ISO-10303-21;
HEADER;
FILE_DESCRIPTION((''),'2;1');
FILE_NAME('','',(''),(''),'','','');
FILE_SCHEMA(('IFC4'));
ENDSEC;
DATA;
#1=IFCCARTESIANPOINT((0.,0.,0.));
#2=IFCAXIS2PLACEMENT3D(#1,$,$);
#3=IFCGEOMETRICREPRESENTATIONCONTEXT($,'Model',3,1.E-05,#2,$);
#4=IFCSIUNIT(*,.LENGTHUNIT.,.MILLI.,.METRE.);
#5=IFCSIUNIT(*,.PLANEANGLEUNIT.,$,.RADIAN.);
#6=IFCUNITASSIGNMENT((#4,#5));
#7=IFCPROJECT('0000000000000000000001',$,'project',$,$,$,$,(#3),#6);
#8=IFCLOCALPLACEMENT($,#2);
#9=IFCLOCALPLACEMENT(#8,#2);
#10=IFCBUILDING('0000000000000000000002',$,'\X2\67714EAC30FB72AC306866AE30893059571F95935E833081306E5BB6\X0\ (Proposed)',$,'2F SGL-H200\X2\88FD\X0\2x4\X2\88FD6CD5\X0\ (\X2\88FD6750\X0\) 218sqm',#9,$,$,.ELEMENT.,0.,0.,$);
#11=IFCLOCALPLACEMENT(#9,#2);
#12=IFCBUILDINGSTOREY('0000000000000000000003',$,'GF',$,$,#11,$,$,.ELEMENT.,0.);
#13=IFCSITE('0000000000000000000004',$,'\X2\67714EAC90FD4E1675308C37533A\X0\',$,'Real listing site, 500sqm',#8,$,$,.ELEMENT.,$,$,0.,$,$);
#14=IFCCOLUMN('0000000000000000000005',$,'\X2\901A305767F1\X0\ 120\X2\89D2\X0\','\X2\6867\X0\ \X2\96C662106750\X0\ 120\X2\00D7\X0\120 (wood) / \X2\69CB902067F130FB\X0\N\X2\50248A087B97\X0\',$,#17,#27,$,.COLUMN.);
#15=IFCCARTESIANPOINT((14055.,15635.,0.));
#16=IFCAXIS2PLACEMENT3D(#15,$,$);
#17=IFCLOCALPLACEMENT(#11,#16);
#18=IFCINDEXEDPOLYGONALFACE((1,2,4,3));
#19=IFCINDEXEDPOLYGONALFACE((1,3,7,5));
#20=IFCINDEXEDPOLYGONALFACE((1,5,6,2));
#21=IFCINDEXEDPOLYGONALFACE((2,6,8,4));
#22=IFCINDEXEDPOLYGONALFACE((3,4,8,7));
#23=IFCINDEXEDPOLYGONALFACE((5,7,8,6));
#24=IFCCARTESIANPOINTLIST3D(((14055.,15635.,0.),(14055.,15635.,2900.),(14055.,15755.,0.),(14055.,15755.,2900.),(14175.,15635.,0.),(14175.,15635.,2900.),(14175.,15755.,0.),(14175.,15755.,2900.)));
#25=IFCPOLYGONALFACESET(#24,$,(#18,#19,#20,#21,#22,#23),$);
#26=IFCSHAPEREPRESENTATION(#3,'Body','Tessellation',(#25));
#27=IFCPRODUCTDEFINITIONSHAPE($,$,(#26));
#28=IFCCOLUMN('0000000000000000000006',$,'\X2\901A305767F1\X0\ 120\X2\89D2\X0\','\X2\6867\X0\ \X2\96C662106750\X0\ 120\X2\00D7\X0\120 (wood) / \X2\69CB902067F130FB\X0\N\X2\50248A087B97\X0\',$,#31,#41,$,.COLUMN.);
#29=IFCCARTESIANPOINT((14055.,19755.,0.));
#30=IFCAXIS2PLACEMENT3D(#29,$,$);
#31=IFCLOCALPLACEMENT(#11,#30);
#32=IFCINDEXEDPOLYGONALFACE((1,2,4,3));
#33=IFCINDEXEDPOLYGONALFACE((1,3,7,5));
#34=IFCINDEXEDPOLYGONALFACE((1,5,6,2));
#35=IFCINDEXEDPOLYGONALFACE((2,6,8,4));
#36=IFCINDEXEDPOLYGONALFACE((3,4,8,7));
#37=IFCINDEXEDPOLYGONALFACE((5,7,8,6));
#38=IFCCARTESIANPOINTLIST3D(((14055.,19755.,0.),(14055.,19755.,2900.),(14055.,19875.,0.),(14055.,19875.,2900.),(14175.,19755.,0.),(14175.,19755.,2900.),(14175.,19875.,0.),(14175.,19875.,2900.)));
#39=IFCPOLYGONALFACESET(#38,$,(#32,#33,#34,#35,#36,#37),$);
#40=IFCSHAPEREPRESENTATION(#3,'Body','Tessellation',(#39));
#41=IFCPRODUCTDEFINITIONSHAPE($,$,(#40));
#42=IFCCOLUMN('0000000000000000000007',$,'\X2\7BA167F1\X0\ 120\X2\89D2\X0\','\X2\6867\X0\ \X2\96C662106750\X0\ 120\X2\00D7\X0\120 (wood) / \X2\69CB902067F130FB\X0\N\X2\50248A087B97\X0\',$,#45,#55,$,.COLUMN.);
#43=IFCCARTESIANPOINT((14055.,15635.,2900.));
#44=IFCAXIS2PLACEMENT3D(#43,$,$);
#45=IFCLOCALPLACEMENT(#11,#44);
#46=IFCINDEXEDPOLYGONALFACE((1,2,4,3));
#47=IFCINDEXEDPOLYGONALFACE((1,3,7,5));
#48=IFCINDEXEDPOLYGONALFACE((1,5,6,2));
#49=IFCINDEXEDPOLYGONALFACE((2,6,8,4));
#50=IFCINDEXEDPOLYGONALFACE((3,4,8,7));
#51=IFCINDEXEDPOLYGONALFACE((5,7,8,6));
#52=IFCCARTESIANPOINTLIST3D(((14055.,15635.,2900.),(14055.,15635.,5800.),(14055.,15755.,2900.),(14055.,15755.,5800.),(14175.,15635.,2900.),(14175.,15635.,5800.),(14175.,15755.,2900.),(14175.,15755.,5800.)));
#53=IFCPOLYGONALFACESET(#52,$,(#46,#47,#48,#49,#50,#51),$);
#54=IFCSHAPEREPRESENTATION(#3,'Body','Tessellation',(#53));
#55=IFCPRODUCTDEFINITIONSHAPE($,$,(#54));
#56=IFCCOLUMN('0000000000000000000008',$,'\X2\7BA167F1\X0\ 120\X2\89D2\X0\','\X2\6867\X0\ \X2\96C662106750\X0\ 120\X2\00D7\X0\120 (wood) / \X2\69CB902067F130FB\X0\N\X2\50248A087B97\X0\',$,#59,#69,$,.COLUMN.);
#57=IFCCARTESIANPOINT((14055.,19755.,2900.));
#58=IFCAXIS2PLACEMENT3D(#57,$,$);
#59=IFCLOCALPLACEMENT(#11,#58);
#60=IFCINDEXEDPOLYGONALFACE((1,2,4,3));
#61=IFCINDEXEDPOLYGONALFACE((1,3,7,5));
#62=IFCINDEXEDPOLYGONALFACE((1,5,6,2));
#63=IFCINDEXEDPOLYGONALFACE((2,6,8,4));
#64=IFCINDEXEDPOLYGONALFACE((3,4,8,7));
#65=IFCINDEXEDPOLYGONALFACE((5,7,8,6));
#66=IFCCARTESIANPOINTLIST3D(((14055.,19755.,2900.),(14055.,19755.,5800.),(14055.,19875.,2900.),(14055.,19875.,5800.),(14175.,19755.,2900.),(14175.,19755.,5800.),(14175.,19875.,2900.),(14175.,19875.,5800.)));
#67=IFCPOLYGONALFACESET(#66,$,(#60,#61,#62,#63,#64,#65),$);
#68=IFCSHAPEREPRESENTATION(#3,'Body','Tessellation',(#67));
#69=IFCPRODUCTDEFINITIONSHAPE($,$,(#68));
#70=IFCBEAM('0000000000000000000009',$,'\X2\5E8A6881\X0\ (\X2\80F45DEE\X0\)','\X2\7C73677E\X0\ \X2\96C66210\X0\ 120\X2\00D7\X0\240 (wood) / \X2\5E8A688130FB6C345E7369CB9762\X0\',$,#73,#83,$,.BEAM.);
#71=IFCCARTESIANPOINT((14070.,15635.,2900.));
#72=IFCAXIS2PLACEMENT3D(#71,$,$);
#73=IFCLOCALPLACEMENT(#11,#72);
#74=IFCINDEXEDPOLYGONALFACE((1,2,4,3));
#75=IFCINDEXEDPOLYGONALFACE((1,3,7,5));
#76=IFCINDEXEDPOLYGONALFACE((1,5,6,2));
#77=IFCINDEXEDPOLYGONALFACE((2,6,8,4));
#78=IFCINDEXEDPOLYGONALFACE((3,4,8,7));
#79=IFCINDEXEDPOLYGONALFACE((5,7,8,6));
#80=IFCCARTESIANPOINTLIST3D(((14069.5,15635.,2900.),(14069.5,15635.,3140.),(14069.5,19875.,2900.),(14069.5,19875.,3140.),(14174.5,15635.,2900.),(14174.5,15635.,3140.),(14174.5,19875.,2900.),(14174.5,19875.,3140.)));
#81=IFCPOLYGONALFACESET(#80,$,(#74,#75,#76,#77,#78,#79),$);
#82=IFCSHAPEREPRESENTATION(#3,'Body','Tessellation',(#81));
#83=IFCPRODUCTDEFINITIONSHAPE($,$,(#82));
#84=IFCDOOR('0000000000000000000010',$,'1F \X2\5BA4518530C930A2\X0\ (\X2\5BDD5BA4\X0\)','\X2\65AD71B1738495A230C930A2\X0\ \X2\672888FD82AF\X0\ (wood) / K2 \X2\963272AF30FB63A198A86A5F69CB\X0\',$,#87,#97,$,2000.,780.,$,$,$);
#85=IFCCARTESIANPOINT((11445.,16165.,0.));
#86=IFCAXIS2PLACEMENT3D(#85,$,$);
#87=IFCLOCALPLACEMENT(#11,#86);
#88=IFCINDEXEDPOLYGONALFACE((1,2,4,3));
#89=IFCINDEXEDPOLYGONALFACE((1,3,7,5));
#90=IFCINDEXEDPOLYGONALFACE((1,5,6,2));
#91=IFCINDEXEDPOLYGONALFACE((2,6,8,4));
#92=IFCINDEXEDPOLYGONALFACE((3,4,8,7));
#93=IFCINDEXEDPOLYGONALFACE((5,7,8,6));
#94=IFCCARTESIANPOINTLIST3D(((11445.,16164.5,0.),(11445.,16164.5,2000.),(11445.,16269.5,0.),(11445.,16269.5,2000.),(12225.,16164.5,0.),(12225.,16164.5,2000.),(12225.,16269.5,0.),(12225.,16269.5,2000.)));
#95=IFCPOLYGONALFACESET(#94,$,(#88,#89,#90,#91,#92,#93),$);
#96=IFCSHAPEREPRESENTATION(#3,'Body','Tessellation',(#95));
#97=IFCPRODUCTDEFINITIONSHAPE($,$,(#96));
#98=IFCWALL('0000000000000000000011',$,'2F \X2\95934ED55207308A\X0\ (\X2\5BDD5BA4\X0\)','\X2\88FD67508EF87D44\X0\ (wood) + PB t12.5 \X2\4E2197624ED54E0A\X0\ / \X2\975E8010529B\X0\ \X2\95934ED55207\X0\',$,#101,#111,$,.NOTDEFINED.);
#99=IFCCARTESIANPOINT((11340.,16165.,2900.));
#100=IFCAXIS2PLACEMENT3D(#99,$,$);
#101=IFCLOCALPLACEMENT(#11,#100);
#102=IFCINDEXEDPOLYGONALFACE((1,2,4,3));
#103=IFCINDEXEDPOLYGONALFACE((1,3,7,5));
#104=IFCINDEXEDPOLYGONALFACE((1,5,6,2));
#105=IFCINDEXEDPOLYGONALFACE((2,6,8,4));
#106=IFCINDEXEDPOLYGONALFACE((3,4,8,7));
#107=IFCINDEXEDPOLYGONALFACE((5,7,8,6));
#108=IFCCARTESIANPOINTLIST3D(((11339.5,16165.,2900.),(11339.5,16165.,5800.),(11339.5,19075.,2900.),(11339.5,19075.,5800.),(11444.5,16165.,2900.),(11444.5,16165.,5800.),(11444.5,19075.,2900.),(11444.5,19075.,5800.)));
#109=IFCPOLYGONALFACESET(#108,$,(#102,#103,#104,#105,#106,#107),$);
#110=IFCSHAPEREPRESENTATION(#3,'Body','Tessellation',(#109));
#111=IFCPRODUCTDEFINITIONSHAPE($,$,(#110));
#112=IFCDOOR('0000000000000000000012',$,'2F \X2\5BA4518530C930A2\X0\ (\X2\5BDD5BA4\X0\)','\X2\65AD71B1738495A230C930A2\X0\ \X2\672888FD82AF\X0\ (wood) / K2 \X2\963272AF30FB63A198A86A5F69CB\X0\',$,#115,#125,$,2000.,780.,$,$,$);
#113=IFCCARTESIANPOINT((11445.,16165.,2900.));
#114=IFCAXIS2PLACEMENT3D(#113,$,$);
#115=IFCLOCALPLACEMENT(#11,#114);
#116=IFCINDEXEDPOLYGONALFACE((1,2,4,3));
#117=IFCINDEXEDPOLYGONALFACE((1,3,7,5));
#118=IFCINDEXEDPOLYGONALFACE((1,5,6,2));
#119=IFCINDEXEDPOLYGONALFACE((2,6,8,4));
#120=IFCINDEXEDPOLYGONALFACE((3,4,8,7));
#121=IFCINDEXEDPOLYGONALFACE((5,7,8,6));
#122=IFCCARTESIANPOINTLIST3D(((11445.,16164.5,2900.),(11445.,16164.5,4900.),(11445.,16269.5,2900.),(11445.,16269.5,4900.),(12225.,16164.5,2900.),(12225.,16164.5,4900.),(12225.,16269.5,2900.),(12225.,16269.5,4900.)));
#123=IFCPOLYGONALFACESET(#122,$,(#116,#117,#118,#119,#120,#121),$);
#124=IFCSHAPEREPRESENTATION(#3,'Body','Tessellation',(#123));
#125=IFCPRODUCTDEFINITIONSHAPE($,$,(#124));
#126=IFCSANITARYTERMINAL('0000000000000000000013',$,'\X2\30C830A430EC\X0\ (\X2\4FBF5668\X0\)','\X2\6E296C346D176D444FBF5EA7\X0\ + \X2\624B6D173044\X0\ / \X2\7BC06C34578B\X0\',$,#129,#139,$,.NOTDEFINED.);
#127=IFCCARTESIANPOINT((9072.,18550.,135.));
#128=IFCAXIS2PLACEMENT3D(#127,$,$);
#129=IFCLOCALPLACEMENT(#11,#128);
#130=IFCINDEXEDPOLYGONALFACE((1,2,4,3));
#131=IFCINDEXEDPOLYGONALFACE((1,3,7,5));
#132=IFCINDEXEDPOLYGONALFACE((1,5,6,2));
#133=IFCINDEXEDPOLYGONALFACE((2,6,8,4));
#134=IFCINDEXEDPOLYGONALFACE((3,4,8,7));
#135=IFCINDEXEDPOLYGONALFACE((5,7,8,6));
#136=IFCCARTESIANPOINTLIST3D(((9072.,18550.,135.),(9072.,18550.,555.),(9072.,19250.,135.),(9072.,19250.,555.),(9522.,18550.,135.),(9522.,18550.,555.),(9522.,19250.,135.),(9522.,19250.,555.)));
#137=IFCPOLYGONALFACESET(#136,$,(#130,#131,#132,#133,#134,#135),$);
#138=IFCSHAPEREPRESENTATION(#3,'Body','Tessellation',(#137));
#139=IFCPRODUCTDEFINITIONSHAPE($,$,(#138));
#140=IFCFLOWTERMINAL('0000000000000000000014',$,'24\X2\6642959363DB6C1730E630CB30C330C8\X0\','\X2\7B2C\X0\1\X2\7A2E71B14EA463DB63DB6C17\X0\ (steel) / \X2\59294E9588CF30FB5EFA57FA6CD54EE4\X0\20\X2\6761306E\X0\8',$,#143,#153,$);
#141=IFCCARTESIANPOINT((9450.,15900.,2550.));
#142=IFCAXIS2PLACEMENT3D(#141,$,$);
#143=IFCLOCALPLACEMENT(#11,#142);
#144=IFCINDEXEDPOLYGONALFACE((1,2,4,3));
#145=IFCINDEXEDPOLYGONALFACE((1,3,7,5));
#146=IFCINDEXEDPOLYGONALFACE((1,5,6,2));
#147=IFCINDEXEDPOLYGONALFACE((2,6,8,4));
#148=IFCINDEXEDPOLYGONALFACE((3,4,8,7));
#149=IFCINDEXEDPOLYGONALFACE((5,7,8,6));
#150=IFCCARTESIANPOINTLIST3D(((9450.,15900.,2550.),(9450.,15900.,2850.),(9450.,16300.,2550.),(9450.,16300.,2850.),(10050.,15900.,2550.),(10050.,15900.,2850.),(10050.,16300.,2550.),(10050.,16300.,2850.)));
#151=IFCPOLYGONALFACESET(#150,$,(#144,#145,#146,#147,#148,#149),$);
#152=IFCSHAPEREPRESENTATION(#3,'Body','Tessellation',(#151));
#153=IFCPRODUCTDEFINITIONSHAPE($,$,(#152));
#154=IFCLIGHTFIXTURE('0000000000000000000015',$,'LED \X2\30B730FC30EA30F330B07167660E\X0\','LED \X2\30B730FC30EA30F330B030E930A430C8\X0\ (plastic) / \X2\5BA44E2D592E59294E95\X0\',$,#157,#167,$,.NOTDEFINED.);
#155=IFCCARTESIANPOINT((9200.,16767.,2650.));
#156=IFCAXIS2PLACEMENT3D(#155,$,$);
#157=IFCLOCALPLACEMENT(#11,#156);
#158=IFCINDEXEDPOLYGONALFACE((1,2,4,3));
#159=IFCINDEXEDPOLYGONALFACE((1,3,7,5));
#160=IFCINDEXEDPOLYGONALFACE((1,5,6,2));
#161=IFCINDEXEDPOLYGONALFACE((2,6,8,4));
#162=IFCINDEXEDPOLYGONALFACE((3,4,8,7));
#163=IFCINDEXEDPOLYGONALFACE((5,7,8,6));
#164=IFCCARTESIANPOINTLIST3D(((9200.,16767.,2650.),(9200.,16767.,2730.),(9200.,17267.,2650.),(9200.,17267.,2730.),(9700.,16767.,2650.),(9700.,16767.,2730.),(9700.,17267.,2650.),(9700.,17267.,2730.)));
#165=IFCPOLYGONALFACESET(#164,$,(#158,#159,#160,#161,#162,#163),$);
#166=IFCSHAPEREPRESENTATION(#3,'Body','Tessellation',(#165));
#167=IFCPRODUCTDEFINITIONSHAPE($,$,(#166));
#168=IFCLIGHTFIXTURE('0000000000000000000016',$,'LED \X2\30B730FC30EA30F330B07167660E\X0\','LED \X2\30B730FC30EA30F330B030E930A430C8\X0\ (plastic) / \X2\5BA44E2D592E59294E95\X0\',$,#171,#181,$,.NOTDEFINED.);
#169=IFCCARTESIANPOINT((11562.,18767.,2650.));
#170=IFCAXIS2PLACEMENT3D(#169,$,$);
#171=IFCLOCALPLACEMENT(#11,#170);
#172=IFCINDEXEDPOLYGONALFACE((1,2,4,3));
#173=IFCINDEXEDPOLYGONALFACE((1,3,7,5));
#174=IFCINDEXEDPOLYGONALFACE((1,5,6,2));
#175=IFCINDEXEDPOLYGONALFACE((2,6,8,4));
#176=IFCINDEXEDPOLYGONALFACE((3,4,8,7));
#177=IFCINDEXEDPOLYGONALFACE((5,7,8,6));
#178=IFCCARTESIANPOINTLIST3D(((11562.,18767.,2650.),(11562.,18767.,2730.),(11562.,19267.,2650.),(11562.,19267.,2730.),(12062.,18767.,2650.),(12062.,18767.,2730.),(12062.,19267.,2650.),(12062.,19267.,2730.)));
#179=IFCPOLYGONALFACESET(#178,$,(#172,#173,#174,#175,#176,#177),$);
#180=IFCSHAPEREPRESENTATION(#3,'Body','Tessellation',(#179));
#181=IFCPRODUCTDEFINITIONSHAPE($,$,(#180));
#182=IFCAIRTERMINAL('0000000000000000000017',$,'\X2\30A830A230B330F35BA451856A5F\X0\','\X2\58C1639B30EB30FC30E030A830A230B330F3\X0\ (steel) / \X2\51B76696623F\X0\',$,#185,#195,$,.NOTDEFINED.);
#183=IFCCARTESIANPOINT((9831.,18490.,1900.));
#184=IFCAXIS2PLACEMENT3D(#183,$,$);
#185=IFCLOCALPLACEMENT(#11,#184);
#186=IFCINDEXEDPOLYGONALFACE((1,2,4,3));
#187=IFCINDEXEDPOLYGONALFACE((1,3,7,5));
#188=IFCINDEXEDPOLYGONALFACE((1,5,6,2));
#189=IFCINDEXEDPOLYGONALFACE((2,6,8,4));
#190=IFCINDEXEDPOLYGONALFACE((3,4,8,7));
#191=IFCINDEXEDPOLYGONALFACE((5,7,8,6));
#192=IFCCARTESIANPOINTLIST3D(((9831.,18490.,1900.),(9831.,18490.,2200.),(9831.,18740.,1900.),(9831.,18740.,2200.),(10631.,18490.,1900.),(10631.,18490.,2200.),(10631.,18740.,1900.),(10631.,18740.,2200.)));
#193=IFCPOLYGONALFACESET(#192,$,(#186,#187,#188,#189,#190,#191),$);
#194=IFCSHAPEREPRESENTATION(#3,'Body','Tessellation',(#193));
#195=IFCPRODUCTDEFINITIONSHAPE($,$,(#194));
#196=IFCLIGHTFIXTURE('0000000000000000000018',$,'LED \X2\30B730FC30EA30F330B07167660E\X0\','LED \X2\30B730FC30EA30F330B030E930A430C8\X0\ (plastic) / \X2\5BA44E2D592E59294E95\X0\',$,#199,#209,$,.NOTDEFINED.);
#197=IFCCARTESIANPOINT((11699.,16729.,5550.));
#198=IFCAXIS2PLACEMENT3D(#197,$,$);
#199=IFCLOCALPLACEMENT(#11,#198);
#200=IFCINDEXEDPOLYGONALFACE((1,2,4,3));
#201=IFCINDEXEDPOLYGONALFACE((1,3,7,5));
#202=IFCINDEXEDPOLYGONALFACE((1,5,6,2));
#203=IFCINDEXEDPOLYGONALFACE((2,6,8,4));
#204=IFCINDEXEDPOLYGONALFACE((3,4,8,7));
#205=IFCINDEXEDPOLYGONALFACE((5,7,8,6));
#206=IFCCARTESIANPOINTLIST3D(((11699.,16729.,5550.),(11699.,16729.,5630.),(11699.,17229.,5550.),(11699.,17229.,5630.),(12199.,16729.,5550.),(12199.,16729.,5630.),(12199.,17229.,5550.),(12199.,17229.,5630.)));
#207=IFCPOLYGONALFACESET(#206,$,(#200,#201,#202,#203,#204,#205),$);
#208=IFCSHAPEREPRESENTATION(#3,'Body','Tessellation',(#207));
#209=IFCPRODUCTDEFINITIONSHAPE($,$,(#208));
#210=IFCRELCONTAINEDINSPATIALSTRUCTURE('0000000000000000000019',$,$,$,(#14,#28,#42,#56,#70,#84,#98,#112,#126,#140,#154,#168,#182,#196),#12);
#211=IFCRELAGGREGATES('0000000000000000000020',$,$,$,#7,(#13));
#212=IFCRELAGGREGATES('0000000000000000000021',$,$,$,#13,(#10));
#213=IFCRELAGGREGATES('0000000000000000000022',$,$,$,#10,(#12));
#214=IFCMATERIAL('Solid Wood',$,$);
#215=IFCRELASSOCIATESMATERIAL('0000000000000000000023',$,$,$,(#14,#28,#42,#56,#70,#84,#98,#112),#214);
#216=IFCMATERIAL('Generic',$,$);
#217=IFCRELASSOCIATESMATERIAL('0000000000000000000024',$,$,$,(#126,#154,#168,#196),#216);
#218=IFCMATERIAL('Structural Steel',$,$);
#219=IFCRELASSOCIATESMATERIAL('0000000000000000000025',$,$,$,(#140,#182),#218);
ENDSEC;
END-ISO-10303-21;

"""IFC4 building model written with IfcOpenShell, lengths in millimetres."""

from ifc_helpers import new_model, si_unit, frame, frame_2d, origin, place, context, project, spatial, rectangle, extrude, material, element, save


model = new_model("IFC4")

# Units and contexts
model_context = context("Model", 3, precision=1e-05, world=origin())
ifc_project = project(units=[si_unit("LENGTHUNIT", "METRE", prefix="MILLI"), si_unit("PLANEANGLEUNIT", "RADIAN")], contexts=[model_context])

# Site, building, storey
site_placement = place(None, origin())
site = spatial("IfcSite", under=ifc_project, at=site_placement, Name="東京都世田谷区", ObjectType="Real listing site, 500sqm", CompositionType="ELEMENT", RefElevation=0.0)
building_placement = place(site_placement, origin())
building = spatial("IfcBuilding", under=site, at=building_placement, Name="東京・犬と暮らす土間広めの家 (Proposed)", ObjectType="2F SGL-H200製2x4製法 (製材) 218sqm", CompositionType="ELEMENT", ElevationOfRefHeight=0.0, ElevationOfTerrain=0.0)
storey_placement = place(building_placement, origin())
storey = spatial("IfcBuildingStorey", under=building, at=storey_placement, Name="GF", CompositionType="ELEMENT", Elevation=0.0)

# Columns
ifc_material_1 = material(Name="Solid Wood")
column_1_placement = place(storey_placement, frame((14055.0, 15635.0, 0.0)))
element("IfcColumn", 1, at=column_1_placement, inside=storey, material=ifc_material_1, Name="通し柱 120角", Description="桧 集成材 120×120 (wood) / 構造柱・N値計算", PredefinedType="COLUMN", context=model_context, shape_type="SweptSolid", body=[
    extrude(rectangle(XDim=120.0, YDim=120.0, at=frame_2d((60.0, 60.0))), frame((14055.0, 15635.0, 0.0)), (0.0, 0.0, 1.0), 2900.0),
])
column_2_placement = place(storey_placement, frame((14055.0, 19755.0, 0.0)))
element("IfcColumn", 2, at=column_2_placement, inside=storey, material=ifc_material_1, Name="通し柱 120角", Description="桧 集成材 120×120 (wood) / 構造柱・N値計算", PredefinedType="COLUMN", context=model_context, shape_type="SweptSolid", body=[
    extrude(rectangle(XDim=120.0, YDim=120.0, at=frame_2d((60.0, 60.0))), frame((14055.0, 19755.0, 0.0)), (0.0, 0.0, 1.0), 2900.0),
])
column_3_placement = place(storey_placement, frame((14055.0, 15635.0, 2900.0)))
element("IfcColumn", 3, at=column_3_placement, inside=storey, material=ifc_material_1, Name="管柱 120角", Description="桧 集成材 120×120 (wood) / 構造柱・N値計算", PredefinedType="COLUMN", context=model_context, shape_type="SweptSolid", body=[
    extrude(rectangle(XDim=120.0, YDim=120.0, at=frame_2d((60.0, 60.0))), frame((14055.0, 15635.0, 2900.0)), (0.0, 0.0, 1.0), 2900.0),
])
column_4_placement = place(storey_placement, frame((14055.0, 19755.0, 2900.0)))
element("IfcColumn", 4, at=column_4_placement, inside=storey, material=ifc_material_1, Name="管柱 120角", Description="桧 集成材 120×120 (wood) / 構造柱・N値計算", PredefinedType="COLUMN", context=model_context, shape_type="SweptSolid", body=[
    extrude(rectangle(XDim=120.0, YDim=120.0, at=frame_2d((60.0, 60.0))), frame((14055.0, 19755.0, 2900.0)), (0.0, 0.0, 1.0), 2900.0),
])

# Beam
beam_1_placement = place(storey_placement, frame((14070.0, 15635.0, 2900.0)))
element("IfcBeam", 5, at=beam_1_placement, inside=storey, material=ifc_material_1, Name="床梁 (胴差)", Description="米松 集成 120×240 (wood) / 床梁・水平構面", PredefinedType="BEAM", context=model_context, shape_type="SweptSolid", body=[
    extrude(rectangle(XDim=105.0, YDim=4240.0, at=frame_2d((52.0, 2120.0))), frame((14070.0, 15635.0, 2900.0)), (0.0, 0.0, 1.0), 240.0),
])

# Door
door_1_placement = place(storey_placement, frame((11445.0, 16165.0, 0.0)))
element("IfcDoor", 6, at=door_1_placement, inside=storey, material=ifc_material_1, Name="1F 室内ドア (寝室)", Description="断熱玄関ドア 木製芯 (wood) / K2 防犯・採風機構", OverallHeight=2000.0, OverallWidth=780.0, context=model_context, shape_type="SweptSolid", body=[
    extrude(rectangle(XDim=780.0, YDim=105.0, at=frame_2d((390.0, 52.0))), frame((11445.0, 16165.0, 0.0)), (0.0, 0.0, 1.0), 2000.0),
])

# Wall
wall_1_placement = place(storey_placement, frame((11340.0, 16165.0, 2900.0)))
element("IfcWall", 7, at=wall_1_placement, inside=storey, material=ifc_material_1, Name="2F 間仕切り (寝室)", Description="製材軸組 (wood) + PB t12.5 両面仕上 / 非耐力 間仕切", PredefinedType="NOTDEFINED", context=model_context, shape_type="SweptSolid", body=[
    extrude(rectangle(XDim=105.0, YDim=2910.0, at=frame_2d((52.0, 1455.0))), frame((11340.0, 16165.0, 2900.0)), (0.0, 0.0, 1.0), 2900.0),
])

# Door
door_2_placement = place(storey_placement, frame((11445.0, 16165.0, 2900.0)))
element("IfcDoor", 8, at=door_2_placement, inside=storey, material=ifc_material_1, Name="2F 室内ドア (寝室)", Description="断熱玄関ドア 木製芯 (wood) / K2 防犯・採風機構", OverallHeight=2000.0, OverallWidth=780.0, context=model_context, shape_type="SweptSolid", body=[
    extrude(rectangle(XDim=780.0, YDim=105.0, at=frame_2d((390.0, 52.0))), frame((11445.0, 16165.0, 2900.0)), (0.0, 0.0, 1.0), 2000.0),
])

# Sanitary terminal
ifc_material_2 = material(Name="Generic")
sanitary_terminal_placement = place(storey_placement, frame((9072.0, 18550.0, 135.0)))
element("IfcSanitaryTerminal", 9, at=sanitary_terminal_placement, inside=storey, material=ifc_material_2, Name="トイレ (便器)", Description="温水洗浄便座 + 手洗い / 節水型", PredefinedType="NOTDEFINED", context=model_context, shape_type="SweptSolid", body=[
    extrude(rectangle(XDim=450.0, YDim=700.0, at=frame_2d((225.0, 350.0))), frame((9072.0, 18550.0, 135.0)), (0.0, 0.0, 1.0), 420.0),
])

# Flow terminal
ifc_material_3 = material(Name="Structural Steel")
flow_terminal_placement = place(storey_placement, frame((9450.0, 15900.0, 2550.0)))
element("IfcFlowTerminal", 10, at=flow_terminal_placement, inside=storey, material=ifc_material_3, Name="24時間換気ユニット", Description="第1種熱交換換気 (steel) / 天井裏・建基法令20条の8", context=model_context, shape_type="SweptSolid", body=[
    extrude(rectangle(XDim=600.0, YDim=400.0, at=frame_2d((300.0, 200.0))), frame((9450.0, 15900.0, 2550.0)), (0.0, 0.0, 1.0), 300.0),
])

# Light fixtures
light_fixture_1_placement = place(storey_placement, frame((9200.0, 16767.0, 2650.0)))
element("IfcLightFixture", 11, at=light_fixture_1_placement, inside=storey, material=ifc_material_2, Name="LED シーリング照明", Description="LED シーリングライト (plastic) / 室中央天井", PredefinedType="NOTDEFINED", context=model_context, shape_type="SweptSolid", body=[
    extrude(rectangle(XDim=500.0, YDim=500.0, at=frame_2d((250.0, 250.0))), frame((9200.0, 16767.0, 2650.0)), (0.0, 0.0, 1.0), 80.0),
])
light_fixture_2_placement = place(storey_placement, frame((11562.0, 18767.0, 2650.0)))
element("IfcLightFixture", 12, at=light_fixture_2_placement, inside=storey, material=ifc_material_2, Name="LED シーリング照明", Description="LED シーリングライト (plastic) / 室中央天井", PredefinedType="NOTDEFINED", context=model_context, shape_type="SweptSolid", body=[
    extrude(rectangle(XDim=500.0, YDim=500.0, at=frame_2d((250.0, 250.0))), frame((11562.0, 18767.0, 2650.0)), (0.0, 0.0, 1.0), 80.0),
])

# Air terminal
air_terminal_1_placement = place(storey_placement, frame((9831.0, 18490.0, 1900.0)))
element("IfcAirTerminal", 13, at=air_terminal_1_placement, inside=storey, material=ifc_material_3, Name="エアコン室内機", Description="壁掛ルームエアコン (steel) / 冷暖房", PredefinedType="NOTDEFINED", context=model_context, shape_type="SweptSolid", body=[
    extrude(rectangle(XDim=800.0, YDim=250.0, at=frame_2d((400.0, 125.0))), frame((9831.0, 18490.0, 1900.0)), (0.0, 0.0, 1.0), 300.0),
])

# Light fixture
light_fixture_3_placement = place(storey_placement, frame((11699.0, 16729.0, 5550.0)))
element("IfcLightFixture", 14, at=light_fixture_3_placement, inside=storey, material=ifc_material_2, Name="LED シーリング照明", Description="LED シーリングライト (plastic) / 室中央天井", PredefinedType="NOTDEFINED", context=model_context, shape_type="SweptSolid", body=[
    extrude(rectangle(XDim=500.0, YDim=500.0, at=frame_2d((250.0, 250.0))), frame((11699.0, 16729.0, 5550.0)), (0.0, 0.0, 1.0), 80.0),
])

save(model, "model.ifc")
